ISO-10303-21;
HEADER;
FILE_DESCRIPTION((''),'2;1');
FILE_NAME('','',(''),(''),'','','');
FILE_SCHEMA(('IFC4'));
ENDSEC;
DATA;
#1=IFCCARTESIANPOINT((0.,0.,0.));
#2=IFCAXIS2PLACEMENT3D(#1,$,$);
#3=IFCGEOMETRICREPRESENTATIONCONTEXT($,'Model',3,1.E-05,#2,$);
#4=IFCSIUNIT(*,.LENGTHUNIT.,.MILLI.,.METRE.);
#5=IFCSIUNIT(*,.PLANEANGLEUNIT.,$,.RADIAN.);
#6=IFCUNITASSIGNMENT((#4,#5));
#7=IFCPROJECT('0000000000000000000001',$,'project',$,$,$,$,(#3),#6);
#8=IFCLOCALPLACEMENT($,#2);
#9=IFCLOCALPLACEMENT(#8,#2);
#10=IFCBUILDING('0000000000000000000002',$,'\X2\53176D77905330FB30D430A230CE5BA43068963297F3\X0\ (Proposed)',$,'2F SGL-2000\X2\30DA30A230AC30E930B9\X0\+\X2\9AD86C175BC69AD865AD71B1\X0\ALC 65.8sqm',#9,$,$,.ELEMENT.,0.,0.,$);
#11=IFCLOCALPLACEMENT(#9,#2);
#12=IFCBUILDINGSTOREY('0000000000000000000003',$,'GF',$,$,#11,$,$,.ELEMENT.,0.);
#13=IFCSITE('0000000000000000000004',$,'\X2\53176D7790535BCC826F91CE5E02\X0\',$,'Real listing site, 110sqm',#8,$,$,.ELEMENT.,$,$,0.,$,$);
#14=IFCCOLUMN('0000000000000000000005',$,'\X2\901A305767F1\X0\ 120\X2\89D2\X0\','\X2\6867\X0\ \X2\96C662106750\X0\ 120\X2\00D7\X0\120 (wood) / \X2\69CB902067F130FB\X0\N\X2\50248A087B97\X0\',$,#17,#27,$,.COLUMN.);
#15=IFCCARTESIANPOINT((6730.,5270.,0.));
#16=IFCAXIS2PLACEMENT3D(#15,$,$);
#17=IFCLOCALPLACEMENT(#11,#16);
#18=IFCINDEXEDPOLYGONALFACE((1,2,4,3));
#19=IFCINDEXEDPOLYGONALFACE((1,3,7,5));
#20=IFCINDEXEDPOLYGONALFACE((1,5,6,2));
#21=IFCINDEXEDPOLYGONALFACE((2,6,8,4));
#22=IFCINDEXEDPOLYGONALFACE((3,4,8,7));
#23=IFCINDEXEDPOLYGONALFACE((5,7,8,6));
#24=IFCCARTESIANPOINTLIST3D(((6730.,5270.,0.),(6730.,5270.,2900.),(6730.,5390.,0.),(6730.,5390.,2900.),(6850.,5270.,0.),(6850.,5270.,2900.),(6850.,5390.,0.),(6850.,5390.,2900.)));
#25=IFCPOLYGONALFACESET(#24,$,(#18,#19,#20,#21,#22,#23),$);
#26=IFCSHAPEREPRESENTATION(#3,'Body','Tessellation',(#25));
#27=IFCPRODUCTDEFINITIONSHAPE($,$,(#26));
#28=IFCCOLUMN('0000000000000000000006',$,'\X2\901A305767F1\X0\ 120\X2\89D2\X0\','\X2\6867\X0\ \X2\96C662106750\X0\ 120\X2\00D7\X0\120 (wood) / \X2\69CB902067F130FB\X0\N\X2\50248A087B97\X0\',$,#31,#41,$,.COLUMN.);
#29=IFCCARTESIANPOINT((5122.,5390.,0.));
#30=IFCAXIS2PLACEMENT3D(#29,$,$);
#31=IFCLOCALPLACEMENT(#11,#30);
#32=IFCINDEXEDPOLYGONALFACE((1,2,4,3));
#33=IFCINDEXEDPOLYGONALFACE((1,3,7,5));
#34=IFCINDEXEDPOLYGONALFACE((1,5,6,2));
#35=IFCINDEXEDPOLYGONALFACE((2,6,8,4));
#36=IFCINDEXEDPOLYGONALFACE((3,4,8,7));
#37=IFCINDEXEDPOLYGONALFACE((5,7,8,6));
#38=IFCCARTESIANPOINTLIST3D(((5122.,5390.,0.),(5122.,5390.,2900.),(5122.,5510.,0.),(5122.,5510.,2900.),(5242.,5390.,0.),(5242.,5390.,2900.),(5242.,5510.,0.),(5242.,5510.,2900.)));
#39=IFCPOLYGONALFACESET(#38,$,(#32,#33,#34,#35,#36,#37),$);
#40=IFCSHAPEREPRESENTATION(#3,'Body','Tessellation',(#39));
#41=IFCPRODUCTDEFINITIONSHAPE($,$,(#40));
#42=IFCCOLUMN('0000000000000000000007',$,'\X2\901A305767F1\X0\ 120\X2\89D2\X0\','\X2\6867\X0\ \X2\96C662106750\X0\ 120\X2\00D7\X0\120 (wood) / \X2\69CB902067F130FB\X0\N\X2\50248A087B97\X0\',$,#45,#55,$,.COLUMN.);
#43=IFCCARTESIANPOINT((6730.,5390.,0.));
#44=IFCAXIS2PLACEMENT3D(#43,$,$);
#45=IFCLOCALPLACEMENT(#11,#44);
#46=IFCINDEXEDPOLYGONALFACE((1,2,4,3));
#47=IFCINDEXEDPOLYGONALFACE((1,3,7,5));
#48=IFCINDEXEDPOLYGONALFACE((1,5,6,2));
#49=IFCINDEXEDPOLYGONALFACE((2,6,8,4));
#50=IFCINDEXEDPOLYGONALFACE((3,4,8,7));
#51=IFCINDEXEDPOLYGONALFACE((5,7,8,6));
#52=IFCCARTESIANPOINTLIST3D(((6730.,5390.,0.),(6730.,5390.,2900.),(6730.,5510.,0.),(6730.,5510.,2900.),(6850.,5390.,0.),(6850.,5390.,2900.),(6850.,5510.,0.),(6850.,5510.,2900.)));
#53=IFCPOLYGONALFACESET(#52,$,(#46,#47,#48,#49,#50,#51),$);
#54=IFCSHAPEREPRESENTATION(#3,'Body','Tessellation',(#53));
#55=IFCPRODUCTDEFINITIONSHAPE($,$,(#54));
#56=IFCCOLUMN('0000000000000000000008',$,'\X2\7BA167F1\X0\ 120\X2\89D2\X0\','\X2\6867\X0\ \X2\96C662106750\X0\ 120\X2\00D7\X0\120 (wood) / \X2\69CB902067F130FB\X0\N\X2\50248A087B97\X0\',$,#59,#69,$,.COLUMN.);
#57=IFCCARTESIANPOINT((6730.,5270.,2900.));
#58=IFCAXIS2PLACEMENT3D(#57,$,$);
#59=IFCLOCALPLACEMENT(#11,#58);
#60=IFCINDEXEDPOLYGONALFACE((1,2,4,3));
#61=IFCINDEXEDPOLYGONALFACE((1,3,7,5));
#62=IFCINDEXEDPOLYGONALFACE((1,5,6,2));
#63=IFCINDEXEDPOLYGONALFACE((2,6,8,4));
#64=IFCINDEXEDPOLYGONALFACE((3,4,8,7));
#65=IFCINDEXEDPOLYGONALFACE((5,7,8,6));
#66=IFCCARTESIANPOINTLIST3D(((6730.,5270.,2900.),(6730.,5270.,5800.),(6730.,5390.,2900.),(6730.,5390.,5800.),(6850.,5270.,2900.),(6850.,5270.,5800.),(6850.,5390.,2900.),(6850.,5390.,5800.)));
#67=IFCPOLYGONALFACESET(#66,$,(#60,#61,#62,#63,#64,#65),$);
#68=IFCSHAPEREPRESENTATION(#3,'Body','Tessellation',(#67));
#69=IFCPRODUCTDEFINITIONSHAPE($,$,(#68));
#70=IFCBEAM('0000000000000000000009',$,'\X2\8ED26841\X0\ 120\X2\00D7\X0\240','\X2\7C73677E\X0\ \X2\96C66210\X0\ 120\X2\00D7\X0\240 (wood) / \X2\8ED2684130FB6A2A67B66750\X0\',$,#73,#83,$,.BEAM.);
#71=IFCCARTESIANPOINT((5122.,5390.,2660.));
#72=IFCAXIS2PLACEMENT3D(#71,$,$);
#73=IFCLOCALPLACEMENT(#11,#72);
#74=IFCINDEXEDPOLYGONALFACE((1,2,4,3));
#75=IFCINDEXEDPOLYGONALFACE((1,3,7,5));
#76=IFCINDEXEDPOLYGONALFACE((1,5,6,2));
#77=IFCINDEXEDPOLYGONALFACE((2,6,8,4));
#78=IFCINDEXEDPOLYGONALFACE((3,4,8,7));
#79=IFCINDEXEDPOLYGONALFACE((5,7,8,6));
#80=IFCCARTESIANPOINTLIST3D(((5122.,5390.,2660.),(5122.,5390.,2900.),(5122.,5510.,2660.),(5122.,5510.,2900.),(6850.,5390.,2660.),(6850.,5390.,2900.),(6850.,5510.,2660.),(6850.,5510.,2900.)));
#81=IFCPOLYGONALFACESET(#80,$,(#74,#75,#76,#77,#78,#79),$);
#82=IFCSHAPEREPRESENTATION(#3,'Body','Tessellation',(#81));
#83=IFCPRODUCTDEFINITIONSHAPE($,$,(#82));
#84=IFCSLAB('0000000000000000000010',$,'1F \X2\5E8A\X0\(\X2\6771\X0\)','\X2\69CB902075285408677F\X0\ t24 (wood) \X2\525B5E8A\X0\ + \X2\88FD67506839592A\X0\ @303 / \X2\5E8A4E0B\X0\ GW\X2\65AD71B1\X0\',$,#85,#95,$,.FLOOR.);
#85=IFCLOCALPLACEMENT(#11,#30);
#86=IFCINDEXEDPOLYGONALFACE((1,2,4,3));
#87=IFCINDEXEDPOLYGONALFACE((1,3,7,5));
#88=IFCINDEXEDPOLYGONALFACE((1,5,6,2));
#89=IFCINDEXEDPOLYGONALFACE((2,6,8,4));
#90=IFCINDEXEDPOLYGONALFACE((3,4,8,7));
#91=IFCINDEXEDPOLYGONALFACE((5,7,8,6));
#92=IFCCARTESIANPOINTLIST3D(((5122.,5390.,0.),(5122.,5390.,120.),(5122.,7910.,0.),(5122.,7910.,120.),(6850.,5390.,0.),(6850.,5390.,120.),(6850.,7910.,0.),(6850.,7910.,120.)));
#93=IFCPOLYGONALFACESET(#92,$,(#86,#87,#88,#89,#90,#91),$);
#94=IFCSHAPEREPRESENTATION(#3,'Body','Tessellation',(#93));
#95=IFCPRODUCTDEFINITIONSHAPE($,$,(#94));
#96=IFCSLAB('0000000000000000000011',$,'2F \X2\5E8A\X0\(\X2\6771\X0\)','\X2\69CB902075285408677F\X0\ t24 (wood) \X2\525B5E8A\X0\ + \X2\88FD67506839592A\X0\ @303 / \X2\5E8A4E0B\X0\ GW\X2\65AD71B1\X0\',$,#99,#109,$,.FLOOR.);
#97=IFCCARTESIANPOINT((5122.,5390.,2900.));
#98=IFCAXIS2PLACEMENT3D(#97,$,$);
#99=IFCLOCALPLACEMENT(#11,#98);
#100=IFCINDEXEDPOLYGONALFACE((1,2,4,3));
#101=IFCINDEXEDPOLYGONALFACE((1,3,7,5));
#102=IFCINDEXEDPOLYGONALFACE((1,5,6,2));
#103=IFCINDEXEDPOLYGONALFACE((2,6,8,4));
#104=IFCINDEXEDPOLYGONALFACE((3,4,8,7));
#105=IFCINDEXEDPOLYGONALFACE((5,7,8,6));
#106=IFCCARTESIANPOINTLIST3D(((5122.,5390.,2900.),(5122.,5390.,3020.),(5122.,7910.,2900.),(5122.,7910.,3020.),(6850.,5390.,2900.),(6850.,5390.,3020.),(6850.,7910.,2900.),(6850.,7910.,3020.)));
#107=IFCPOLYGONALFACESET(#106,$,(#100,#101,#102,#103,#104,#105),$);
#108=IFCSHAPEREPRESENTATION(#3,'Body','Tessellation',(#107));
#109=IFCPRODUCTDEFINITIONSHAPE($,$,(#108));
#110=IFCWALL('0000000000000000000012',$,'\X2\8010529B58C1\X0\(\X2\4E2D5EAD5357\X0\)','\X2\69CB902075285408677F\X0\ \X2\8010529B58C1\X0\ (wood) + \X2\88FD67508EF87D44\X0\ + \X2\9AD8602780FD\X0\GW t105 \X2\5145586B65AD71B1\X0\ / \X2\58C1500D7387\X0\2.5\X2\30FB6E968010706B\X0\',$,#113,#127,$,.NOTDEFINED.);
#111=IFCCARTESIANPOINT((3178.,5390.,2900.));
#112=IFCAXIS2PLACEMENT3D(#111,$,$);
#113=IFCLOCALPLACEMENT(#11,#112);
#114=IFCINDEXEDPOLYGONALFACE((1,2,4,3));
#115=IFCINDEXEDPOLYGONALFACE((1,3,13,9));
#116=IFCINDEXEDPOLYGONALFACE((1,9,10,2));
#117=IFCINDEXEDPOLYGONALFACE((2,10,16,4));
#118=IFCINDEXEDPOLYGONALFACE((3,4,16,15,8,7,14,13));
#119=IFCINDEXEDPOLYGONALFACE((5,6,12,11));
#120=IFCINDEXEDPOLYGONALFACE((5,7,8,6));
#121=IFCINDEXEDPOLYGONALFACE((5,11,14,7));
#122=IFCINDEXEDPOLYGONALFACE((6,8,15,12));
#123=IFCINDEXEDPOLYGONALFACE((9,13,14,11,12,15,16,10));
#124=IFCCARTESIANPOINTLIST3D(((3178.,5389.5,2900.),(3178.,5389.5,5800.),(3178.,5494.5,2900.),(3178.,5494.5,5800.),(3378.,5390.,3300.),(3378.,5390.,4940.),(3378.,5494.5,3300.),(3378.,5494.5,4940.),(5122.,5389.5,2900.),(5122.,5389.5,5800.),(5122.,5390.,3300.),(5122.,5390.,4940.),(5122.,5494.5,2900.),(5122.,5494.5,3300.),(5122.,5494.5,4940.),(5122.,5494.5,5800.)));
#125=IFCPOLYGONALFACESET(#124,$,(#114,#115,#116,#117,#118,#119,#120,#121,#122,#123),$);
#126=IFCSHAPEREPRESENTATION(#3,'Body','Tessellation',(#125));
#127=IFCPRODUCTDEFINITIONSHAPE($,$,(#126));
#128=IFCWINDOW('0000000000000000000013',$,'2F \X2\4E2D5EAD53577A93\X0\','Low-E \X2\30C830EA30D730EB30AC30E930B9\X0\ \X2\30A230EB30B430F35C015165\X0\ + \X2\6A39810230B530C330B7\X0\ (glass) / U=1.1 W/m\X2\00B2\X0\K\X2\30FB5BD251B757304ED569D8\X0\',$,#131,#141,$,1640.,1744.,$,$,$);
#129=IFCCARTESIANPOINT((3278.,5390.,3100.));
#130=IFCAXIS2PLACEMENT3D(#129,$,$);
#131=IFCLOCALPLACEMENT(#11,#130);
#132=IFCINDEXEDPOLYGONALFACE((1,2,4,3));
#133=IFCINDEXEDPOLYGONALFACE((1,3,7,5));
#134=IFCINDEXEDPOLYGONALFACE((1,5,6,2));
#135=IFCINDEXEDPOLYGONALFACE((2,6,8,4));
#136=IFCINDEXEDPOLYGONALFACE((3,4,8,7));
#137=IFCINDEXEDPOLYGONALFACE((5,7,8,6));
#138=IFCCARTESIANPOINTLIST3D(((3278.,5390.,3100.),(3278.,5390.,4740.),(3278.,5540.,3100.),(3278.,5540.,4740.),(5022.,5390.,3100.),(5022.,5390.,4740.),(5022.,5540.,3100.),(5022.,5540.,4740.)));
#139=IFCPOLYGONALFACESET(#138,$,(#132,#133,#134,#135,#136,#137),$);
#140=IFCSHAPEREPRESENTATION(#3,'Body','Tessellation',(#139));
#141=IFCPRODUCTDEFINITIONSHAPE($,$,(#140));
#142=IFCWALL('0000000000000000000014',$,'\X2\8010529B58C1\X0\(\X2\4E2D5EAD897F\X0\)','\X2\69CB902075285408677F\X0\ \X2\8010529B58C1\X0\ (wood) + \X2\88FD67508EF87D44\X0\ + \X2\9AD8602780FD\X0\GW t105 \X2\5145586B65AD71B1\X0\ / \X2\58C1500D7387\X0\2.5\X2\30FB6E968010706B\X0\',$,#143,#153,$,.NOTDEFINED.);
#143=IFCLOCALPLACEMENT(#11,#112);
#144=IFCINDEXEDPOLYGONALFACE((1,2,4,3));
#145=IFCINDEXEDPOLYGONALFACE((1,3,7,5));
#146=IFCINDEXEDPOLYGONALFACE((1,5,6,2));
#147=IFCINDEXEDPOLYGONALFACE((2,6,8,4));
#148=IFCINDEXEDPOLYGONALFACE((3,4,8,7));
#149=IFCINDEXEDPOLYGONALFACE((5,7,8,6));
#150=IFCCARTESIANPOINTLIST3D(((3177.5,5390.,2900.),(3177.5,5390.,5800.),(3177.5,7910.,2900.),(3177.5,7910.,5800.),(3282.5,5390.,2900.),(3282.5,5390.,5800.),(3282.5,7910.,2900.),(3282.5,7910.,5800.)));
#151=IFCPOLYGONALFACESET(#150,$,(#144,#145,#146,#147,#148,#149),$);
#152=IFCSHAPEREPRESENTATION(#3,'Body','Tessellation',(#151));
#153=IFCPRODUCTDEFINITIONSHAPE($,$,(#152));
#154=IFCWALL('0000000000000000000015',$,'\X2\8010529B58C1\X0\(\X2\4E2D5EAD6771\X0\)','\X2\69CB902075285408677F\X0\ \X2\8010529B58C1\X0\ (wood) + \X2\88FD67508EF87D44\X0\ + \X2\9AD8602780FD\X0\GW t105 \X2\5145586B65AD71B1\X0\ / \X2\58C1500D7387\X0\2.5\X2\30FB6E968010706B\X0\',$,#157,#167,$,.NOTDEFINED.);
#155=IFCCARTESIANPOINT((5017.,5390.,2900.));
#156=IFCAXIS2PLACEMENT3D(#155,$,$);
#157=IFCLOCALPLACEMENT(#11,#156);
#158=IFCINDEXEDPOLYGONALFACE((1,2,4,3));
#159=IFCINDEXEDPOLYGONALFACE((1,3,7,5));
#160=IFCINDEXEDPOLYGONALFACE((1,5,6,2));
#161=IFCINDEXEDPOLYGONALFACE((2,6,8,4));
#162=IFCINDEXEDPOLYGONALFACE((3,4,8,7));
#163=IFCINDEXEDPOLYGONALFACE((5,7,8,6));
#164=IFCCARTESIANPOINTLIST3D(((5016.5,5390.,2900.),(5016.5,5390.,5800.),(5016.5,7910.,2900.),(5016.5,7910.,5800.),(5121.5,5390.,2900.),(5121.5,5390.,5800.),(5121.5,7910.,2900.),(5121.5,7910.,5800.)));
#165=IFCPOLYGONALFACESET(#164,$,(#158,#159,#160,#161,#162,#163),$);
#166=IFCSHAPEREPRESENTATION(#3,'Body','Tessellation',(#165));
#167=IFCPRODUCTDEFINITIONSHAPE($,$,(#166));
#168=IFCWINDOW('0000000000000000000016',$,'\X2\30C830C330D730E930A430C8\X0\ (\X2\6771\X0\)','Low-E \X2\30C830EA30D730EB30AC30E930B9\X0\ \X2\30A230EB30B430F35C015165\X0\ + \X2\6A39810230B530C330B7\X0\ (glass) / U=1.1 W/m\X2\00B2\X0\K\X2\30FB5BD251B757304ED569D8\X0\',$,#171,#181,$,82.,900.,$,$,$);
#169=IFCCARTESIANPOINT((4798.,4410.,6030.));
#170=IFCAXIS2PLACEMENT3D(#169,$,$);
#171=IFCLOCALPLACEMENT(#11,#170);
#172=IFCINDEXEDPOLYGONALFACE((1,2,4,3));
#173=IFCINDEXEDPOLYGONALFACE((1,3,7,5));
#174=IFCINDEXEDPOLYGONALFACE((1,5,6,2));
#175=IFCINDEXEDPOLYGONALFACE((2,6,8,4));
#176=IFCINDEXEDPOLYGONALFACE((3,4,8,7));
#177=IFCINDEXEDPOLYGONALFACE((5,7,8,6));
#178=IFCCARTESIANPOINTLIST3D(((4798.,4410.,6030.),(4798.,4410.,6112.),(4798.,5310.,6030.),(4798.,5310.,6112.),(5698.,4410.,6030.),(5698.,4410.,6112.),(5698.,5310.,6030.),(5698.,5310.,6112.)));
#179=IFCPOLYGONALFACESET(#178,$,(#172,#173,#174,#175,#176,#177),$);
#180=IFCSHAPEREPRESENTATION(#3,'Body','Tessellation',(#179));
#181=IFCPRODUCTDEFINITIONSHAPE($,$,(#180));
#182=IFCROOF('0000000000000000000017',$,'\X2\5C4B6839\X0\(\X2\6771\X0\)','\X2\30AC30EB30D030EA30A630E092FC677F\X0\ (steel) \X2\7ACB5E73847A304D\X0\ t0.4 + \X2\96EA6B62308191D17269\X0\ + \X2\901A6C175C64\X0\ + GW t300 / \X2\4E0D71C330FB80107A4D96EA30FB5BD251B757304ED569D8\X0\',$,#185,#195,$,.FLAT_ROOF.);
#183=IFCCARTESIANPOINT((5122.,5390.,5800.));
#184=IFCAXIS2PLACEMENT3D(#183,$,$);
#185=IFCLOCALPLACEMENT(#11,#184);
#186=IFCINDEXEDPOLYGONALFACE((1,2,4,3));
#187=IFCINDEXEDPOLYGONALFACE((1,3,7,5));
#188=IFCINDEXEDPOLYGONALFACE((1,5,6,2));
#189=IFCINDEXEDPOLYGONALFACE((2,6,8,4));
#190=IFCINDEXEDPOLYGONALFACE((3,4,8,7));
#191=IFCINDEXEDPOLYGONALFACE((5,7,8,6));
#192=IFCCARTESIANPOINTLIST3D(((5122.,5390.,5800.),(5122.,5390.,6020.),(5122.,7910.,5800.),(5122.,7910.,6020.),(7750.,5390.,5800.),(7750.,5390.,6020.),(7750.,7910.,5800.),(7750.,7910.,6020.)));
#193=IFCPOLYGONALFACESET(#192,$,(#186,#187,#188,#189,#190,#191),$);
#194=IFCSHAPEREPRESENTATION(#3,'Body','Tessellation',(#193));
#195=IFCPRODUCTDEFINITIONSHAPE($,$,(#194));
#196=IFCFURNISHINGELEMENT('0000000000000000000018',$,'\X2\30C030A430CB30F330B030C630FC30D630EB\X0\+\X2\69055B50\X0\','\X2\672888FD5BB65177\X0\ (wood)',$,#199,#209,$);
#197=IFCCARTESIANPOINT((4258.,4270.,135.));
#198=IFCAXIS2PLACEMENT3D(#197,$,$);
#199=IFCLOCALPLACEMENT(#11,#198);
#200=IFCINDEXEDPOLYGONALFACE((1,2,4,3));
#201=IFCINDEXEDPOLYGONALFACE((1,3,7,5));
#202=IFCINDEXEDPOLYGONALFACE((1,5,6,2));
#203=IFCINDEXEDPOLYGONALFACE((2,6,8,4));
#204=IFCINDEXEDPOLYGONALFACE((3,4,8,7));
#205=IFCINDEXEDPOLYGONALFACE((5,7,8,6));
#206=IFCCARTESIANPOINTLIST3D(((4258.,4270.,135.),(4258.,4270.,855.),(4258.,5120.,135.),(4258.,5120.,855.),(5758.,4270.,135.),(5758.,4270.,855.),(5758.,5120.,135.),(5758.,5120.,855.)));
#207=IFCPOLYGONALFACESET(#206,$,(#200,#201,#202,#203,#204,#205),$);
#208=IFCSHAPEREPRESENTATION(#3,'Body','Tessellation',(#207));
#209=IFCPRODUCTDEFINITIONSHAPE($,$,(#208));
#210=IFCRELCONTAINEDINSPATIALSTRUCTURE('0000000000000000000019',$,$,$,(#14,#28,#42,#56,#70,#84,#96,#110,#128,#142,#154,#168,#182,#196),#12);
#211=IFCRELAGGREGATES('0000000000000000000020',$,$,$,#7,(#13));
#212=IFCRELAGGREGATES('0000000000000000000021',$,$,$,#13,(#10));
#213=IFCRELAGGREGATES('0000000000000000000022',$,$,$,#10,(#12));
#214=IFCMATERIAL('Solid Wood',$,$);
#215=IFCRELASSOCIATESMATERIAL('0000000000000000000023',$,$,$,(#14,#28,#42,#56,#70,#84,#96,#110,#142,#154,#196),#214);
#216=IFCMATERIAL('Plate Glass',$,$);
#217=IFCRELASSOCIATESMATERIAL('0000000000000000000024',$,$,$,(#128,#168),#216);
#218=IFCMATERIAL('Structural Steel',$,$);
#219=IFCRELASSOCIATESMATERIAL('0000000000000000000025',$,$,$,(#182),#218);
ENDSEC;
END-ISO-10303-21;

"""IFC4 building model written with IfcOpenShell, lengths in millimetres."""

from ifc_helpers import new_model, si_unit, frame, frame_2d, origin, place, context, project, spatial, rectangle, extrude, material, element, fill, save


model = new_model("IFC4")

# Units and contexts
model_context = context("Model", 3, precision=1e-05, world=origin())
ifc_project = project(units=[si_unit("LENGTHUNIT", "METRE", prefix="MILLI"), si_unit("PLANEANGLEUNIT", "RADIAN")], contexts=[model_context])

# Site, building, storey
site_placement = place(None, origin())
site = spatial("IfcSite", under=ifc_project, at=site_placement, Name="北海道富良野市", ObjectType="Real listing site, 110sqm", CompositionType="ELEMENT", RefElevation=0.0)
building_placement = place(site_placement, origin())
building = spatial("IfcBuilding", under=site, at=building_placement, Name="北海道・ピアノ室と防音 (Proposed)", ObjectType="2F SGL-2000ペアガラス+高気密高断熱ALC 65.8sqm", CompositionType="ELEMENT", ElevationOfRefHeight=0.0, ElevationOfTerrain=0.0)
storey_placement = place(building_placement, origin())
storey = spatial("IfcBuildingStorey", under=building, at=storey_placement, Name="GF", CompositionType="ELEMENT", Elevation=0.0)

# Columns
ifc_material_1 = material(Name="Solid Wood")
column_1_placement = place(storey_placement, frame((6730.0, 5270.0, 0.0)))
element("IfcColumn", 1, at=column_1_placement, inside=storey, material=ifc_material_1, Name="通し柱 120角", Description="桧 集成材 120×120 (wood) / 構造柱・N値計算", PredefinedType="COLUMN", context=model_context, shape_type="SweptSolid", body=[
    extrude(rectangle(XDim=120.0, YDim=120.0, at=frame_2d((60.0, 60.0))), frame((6730.0, 5270.0, 0.0)), (0.0, 0.0, 1.0), 2900.0),
])
column_2_placement = place(storey_placement, frame((5122.0, 5390.0, 0.0)))
element("IfcColumn", 2, at=column_2_placement, inside=storey, material=ifc_material_1, Name="通し柱 120角", Description="桧 集成材 120×120 (wood) / 構造柱・N値計算", PredefinedType="COLUMN", context=model_context, shape_type="SweptSolid", body=[
    extrude(rectangle(XDim=120.0, YDim=120.0, at=frame_2d((60.0, 60.0))), frame((5122.0, 5390.0, 0.0)), (0.0, 0.0, 1.0), 2900.0),
])
column_3_placement = place(storey_placement, frame((6730.0, 5390.0, 0.0)))
element("IfcColumn", 3, at=column_3_placement, inside=storey, material=ifc_material_1, Name="通し柱 120角", Description="桧 集成材 120×120 (wood) / 構造柱・N値計算", PredefinedType="COLUMN", context=model_context, shape_type="SweptSolid", body=[
    extrude(rectangle(XDim=120.0, YDim=120.0, at=frame_2d((60.0, 60.0))), frame((6730.0, 5390.0, 0.0)), (0.0, 0.0, 1.0), 2900.0),
])
column_4_placement = place(storey_placement, frame((6730.0, 5270.0, 2900.0)))
element("IfcColumn", 4, at=column_4_placement, inside=storey, material=ifc_material_1, Name="管柱 120角", Description="桧 集成材 120×120 (wood) / 構造柱・N値計算", PredefinedType="COLUMN", context=model_context, shape_type="SweptSolid", body=[
    extrude(rectangle(XDim=120.0, YDim=120.0, at=frame_2d((60.0, 60.0))), frame((6730.0, 5270.0, 2900.0)), (0.0, 0.0, 1.0), 2900.0),
])

# Beam
beam_1_placement = place(storey_placement, frame((5122.0, 5390.0, 2660.0)))
element("IfcBeam", 5, at=beam_1_placement, inside=storey, material=ifc_material_1, Name="軒桁 120×240", Description="米松 集成 120×240 (wood) / 軒桁・横架材", PredefinedType="BEAM", context=model_context, shape_type="SweptSolid", body=[
    extrude(rectangle(XDim=1728.0, YDim=120.0, at=frame_2d((864.0, 60.0))), frame((5122.0, 5390.0, 2660.0)), (0.0, 0.0, 1.0), 240.0),
])

# Slabs
slab_1_placement = place(storey_placement, frame((5122.0, 5390.0, 0.0)))
element("IfcSlab", 6, at=slab_1_placement, inside=storey, material=ifc_material_1, Name="1F 床(東)", Description="構造用合板 t24 (wood) 剛床 + 製材根太 @303 / 床下 GW断熱", PredefinedType="FLOOR", context=model_context, shape_type="SweptSolid", body=[
    extrude(rectangle(XDim=1728.0, YDim=2520.0, at=frame_2d((864.0, 1260.0))), frame((5122.0, 5390.0, 0.0)), (0.0, 0.0, 1.0), 120.0),
])
slab_2_placement = place(storey_placement, frame((5122.0, 5390.0, 2900.0)))
element("IfcSlab", 7, at=slab_2_placement, inside=storey, material=ifc_material_1, Name="2F 床(東)", Description="構造用合板 t24 (wood) 剛床 + 製材根太 @303 / 床下 GW断熱", PredefinedType="FLOOR", context=model_context, shape_type="SweptSolid", body=[
    extrude(rectangle(XDim=1728.0, YDim=2520.0, at=frame_2d((864.0, 1260.0))), frame((5122.0, 5390.0, 2900.0)), (0.0, 0.0, 1.0), 120.0),
])

# Wall, opening, window
wall_1_placement = place(storey_placement, frame((3178.0, 5390.0, 2900.0)))
wall_1 = element("IfcWall", 8, at=wall_1_placement, inside=storey, material=ifc_material_1, Name="耐力壁(中庭南)", Description="構造用合板 耐力壁 (wood) + 製材軸組 + 高性能GW t105 充填断熱 / 壁倍率2.5・準耐火", PredefinedType="NOTDEFINED", context=model_context, shape_type="SweptSolid", body=[
    extrude(rectangle(XDim=1944.0, YDim=105.0, at=frame_2d((972.0, 52.0))), frame((3178.0, 5390.0, 2900.0)), (0.0, 0.0, 1.0), 2900.0),
])
opening_placement = place(storey_placement, frame((3278.0, 5390.0, 3100.0)))
opening = element("IfcOpeningElement", 9, at=opening_placement, cuts=wall_1, PredefinedType="NOTDEFINED", context=model_context, shape_type="SweptSolid", body=[
    extrude(rectangle(XDim=1744.0, YDim=150.0, at=frame_2d((872.0, 75.0))), frame((3278.0, 5390.0, 3100.0)), (0.0, 0.0, 1.0), 1640.0),
])
ifc_material_2 = material(Name="Plate Glass")
window_1_placement = place(storey_placement, frame((3278.0, 5390.0, 3100.0)))
window_1 = element("IfcWindow", 10, at=window_1_placement, inside=storey, material=ifc_material_2, Name="2F 中庭南窓", Description="Low-E トリプルガラス アルゴン封入 + 樹脂サッシ (glass) / U=1.1 W/m²K・寒冷地仕様", OverallHeight=1640.0, OverallWidth=1744.0, context=model_context, shape_type="SweptSolid", body=[
    extrude(rectangle(XDim=1744.0, YDim=150.0, at=frame_2d((872.0, 75.0))), frame((3278.0, 5390.0, 3100.0)), (0.0, 0.0, 1.0), 1640.0),
])
fill(opening, window_1)

# Walls
wall_2_placement = place(storey_placement, frame((3178.0, 5390.0, 2900.0)))
element("IfcWall", 11, at=wall_2_placement, inside=storey, material=ifc_material_1, Name="耐力壁(中庭西)", Description="構造用合板 耐力壁 (wood) + 製材軸組 + 高性能GW t105 充填断熱 / 壁倍率2.5・準耐火", PredefinedType="NOTDEFINED", context=model_context, shape_type="SweptSolid", body=[
    extrude(rectangle(XDim=105.0, YDim=2520.0, at=frame_2d((52.0, 1260.0))), frame((3178.0, 5390.0, 2900.0)), (0.0, 0.0, 1.0), 2900.0),
])
wall_3_placement = place(storey_placement, frame((5017.0, 5390.0, 2900.0)))
element("IfcWall", 12, at=wall_3_placement, inside=storey, material=ifc_material_1, Name="耐力壁(中庭東)", Description="構造用合板 耐力壁 (wood) + 製材軸組 + 高性能GW t105 充填断熱 / 壁倍率2.5・準耐火", PredefinedType="NOTDEFINED", context=model_context, shape_type="SweptSolid", body=[
    extrude(rectangle(XDim=105.0, YDim=2520.0, at=frame_2d((52.0, 1260.0))), frame((5017.0, 5390.0, 2900.0)), (0.0, 0.0, 1.0), 2900.0),
])

# Window
window_2_placement = place(storey_placement, frame((4798.0, 4410.0, 6030.0)))
element("IfcWindow", 13, at=window_2_placement, inside=storey, material=ifc_material_2, Name="トップライト (東)", Description="Low-E トリプルガラス アルゴン封入 + 樹脂サッシ (glass) / U=1.1 W/m²K・寒冷地仕様", OverallHeight=82.0, OverallWidth=900.0, context=model_context, shape_type="SweptSolid", body=[
    extrude(rectangle(XDim=900.0, YDim=900.0, at=frame_2d((450.0, 450.0))), frame((4798.0, 4410.0, 6030.0)), (0.0, 0.0, 1.0), 82.0),
])

# Roof
ifc_material_3 = material(Name="Structural Steel")
for number, where, name in (
    (14, (5122.0, 5390.0, 5800.0), "屋根(東)"),
):
    element("IfcRoof", number, at=place(storey_placement, frame(where)), inside=storey, material=ifc_material_3, Name=name, Description="ガルバリウム鋼板 (steel) 立平葺き t0.4 + 雪止め金物 + 通気層 + GW t300 / 不燃・耐積雪・寒冷地仕様", PredefinedType="FLAT_ROOF", context=model_context, shape_type="SweptSolid", body=[
        extrude(rectangle(XDim=2628.0, YDim=2520.0, at=frame_2d((1314.0, 1260.0))), frame((5122.0, 5390.0, 5800.0)), (0.0, 0.0, 1.0), 220.0),
    ])

# Furnishing element
furnishing_1_placement = place(storey_placement, frame((4258.0, 4270.0, 135.0)))
element("IfcFurnishingElement", 15, at=furnishing_1_placement, inside=storey, material=ifc_material_1, Name="ダイニングテーブル+椅子", Description="木製家具 (wood)", context=model_context, shape_type="SweptSolid", body=[
    extrude(rectangle(XDim=1500.0, YDim=850.0, at=frame_2d((750.0, 425.0))), frame((4258.0, 4270.0, 135.0)), (0.0, 0.0, 1.0), 720.0),
])

save(model, "model.ifc")
